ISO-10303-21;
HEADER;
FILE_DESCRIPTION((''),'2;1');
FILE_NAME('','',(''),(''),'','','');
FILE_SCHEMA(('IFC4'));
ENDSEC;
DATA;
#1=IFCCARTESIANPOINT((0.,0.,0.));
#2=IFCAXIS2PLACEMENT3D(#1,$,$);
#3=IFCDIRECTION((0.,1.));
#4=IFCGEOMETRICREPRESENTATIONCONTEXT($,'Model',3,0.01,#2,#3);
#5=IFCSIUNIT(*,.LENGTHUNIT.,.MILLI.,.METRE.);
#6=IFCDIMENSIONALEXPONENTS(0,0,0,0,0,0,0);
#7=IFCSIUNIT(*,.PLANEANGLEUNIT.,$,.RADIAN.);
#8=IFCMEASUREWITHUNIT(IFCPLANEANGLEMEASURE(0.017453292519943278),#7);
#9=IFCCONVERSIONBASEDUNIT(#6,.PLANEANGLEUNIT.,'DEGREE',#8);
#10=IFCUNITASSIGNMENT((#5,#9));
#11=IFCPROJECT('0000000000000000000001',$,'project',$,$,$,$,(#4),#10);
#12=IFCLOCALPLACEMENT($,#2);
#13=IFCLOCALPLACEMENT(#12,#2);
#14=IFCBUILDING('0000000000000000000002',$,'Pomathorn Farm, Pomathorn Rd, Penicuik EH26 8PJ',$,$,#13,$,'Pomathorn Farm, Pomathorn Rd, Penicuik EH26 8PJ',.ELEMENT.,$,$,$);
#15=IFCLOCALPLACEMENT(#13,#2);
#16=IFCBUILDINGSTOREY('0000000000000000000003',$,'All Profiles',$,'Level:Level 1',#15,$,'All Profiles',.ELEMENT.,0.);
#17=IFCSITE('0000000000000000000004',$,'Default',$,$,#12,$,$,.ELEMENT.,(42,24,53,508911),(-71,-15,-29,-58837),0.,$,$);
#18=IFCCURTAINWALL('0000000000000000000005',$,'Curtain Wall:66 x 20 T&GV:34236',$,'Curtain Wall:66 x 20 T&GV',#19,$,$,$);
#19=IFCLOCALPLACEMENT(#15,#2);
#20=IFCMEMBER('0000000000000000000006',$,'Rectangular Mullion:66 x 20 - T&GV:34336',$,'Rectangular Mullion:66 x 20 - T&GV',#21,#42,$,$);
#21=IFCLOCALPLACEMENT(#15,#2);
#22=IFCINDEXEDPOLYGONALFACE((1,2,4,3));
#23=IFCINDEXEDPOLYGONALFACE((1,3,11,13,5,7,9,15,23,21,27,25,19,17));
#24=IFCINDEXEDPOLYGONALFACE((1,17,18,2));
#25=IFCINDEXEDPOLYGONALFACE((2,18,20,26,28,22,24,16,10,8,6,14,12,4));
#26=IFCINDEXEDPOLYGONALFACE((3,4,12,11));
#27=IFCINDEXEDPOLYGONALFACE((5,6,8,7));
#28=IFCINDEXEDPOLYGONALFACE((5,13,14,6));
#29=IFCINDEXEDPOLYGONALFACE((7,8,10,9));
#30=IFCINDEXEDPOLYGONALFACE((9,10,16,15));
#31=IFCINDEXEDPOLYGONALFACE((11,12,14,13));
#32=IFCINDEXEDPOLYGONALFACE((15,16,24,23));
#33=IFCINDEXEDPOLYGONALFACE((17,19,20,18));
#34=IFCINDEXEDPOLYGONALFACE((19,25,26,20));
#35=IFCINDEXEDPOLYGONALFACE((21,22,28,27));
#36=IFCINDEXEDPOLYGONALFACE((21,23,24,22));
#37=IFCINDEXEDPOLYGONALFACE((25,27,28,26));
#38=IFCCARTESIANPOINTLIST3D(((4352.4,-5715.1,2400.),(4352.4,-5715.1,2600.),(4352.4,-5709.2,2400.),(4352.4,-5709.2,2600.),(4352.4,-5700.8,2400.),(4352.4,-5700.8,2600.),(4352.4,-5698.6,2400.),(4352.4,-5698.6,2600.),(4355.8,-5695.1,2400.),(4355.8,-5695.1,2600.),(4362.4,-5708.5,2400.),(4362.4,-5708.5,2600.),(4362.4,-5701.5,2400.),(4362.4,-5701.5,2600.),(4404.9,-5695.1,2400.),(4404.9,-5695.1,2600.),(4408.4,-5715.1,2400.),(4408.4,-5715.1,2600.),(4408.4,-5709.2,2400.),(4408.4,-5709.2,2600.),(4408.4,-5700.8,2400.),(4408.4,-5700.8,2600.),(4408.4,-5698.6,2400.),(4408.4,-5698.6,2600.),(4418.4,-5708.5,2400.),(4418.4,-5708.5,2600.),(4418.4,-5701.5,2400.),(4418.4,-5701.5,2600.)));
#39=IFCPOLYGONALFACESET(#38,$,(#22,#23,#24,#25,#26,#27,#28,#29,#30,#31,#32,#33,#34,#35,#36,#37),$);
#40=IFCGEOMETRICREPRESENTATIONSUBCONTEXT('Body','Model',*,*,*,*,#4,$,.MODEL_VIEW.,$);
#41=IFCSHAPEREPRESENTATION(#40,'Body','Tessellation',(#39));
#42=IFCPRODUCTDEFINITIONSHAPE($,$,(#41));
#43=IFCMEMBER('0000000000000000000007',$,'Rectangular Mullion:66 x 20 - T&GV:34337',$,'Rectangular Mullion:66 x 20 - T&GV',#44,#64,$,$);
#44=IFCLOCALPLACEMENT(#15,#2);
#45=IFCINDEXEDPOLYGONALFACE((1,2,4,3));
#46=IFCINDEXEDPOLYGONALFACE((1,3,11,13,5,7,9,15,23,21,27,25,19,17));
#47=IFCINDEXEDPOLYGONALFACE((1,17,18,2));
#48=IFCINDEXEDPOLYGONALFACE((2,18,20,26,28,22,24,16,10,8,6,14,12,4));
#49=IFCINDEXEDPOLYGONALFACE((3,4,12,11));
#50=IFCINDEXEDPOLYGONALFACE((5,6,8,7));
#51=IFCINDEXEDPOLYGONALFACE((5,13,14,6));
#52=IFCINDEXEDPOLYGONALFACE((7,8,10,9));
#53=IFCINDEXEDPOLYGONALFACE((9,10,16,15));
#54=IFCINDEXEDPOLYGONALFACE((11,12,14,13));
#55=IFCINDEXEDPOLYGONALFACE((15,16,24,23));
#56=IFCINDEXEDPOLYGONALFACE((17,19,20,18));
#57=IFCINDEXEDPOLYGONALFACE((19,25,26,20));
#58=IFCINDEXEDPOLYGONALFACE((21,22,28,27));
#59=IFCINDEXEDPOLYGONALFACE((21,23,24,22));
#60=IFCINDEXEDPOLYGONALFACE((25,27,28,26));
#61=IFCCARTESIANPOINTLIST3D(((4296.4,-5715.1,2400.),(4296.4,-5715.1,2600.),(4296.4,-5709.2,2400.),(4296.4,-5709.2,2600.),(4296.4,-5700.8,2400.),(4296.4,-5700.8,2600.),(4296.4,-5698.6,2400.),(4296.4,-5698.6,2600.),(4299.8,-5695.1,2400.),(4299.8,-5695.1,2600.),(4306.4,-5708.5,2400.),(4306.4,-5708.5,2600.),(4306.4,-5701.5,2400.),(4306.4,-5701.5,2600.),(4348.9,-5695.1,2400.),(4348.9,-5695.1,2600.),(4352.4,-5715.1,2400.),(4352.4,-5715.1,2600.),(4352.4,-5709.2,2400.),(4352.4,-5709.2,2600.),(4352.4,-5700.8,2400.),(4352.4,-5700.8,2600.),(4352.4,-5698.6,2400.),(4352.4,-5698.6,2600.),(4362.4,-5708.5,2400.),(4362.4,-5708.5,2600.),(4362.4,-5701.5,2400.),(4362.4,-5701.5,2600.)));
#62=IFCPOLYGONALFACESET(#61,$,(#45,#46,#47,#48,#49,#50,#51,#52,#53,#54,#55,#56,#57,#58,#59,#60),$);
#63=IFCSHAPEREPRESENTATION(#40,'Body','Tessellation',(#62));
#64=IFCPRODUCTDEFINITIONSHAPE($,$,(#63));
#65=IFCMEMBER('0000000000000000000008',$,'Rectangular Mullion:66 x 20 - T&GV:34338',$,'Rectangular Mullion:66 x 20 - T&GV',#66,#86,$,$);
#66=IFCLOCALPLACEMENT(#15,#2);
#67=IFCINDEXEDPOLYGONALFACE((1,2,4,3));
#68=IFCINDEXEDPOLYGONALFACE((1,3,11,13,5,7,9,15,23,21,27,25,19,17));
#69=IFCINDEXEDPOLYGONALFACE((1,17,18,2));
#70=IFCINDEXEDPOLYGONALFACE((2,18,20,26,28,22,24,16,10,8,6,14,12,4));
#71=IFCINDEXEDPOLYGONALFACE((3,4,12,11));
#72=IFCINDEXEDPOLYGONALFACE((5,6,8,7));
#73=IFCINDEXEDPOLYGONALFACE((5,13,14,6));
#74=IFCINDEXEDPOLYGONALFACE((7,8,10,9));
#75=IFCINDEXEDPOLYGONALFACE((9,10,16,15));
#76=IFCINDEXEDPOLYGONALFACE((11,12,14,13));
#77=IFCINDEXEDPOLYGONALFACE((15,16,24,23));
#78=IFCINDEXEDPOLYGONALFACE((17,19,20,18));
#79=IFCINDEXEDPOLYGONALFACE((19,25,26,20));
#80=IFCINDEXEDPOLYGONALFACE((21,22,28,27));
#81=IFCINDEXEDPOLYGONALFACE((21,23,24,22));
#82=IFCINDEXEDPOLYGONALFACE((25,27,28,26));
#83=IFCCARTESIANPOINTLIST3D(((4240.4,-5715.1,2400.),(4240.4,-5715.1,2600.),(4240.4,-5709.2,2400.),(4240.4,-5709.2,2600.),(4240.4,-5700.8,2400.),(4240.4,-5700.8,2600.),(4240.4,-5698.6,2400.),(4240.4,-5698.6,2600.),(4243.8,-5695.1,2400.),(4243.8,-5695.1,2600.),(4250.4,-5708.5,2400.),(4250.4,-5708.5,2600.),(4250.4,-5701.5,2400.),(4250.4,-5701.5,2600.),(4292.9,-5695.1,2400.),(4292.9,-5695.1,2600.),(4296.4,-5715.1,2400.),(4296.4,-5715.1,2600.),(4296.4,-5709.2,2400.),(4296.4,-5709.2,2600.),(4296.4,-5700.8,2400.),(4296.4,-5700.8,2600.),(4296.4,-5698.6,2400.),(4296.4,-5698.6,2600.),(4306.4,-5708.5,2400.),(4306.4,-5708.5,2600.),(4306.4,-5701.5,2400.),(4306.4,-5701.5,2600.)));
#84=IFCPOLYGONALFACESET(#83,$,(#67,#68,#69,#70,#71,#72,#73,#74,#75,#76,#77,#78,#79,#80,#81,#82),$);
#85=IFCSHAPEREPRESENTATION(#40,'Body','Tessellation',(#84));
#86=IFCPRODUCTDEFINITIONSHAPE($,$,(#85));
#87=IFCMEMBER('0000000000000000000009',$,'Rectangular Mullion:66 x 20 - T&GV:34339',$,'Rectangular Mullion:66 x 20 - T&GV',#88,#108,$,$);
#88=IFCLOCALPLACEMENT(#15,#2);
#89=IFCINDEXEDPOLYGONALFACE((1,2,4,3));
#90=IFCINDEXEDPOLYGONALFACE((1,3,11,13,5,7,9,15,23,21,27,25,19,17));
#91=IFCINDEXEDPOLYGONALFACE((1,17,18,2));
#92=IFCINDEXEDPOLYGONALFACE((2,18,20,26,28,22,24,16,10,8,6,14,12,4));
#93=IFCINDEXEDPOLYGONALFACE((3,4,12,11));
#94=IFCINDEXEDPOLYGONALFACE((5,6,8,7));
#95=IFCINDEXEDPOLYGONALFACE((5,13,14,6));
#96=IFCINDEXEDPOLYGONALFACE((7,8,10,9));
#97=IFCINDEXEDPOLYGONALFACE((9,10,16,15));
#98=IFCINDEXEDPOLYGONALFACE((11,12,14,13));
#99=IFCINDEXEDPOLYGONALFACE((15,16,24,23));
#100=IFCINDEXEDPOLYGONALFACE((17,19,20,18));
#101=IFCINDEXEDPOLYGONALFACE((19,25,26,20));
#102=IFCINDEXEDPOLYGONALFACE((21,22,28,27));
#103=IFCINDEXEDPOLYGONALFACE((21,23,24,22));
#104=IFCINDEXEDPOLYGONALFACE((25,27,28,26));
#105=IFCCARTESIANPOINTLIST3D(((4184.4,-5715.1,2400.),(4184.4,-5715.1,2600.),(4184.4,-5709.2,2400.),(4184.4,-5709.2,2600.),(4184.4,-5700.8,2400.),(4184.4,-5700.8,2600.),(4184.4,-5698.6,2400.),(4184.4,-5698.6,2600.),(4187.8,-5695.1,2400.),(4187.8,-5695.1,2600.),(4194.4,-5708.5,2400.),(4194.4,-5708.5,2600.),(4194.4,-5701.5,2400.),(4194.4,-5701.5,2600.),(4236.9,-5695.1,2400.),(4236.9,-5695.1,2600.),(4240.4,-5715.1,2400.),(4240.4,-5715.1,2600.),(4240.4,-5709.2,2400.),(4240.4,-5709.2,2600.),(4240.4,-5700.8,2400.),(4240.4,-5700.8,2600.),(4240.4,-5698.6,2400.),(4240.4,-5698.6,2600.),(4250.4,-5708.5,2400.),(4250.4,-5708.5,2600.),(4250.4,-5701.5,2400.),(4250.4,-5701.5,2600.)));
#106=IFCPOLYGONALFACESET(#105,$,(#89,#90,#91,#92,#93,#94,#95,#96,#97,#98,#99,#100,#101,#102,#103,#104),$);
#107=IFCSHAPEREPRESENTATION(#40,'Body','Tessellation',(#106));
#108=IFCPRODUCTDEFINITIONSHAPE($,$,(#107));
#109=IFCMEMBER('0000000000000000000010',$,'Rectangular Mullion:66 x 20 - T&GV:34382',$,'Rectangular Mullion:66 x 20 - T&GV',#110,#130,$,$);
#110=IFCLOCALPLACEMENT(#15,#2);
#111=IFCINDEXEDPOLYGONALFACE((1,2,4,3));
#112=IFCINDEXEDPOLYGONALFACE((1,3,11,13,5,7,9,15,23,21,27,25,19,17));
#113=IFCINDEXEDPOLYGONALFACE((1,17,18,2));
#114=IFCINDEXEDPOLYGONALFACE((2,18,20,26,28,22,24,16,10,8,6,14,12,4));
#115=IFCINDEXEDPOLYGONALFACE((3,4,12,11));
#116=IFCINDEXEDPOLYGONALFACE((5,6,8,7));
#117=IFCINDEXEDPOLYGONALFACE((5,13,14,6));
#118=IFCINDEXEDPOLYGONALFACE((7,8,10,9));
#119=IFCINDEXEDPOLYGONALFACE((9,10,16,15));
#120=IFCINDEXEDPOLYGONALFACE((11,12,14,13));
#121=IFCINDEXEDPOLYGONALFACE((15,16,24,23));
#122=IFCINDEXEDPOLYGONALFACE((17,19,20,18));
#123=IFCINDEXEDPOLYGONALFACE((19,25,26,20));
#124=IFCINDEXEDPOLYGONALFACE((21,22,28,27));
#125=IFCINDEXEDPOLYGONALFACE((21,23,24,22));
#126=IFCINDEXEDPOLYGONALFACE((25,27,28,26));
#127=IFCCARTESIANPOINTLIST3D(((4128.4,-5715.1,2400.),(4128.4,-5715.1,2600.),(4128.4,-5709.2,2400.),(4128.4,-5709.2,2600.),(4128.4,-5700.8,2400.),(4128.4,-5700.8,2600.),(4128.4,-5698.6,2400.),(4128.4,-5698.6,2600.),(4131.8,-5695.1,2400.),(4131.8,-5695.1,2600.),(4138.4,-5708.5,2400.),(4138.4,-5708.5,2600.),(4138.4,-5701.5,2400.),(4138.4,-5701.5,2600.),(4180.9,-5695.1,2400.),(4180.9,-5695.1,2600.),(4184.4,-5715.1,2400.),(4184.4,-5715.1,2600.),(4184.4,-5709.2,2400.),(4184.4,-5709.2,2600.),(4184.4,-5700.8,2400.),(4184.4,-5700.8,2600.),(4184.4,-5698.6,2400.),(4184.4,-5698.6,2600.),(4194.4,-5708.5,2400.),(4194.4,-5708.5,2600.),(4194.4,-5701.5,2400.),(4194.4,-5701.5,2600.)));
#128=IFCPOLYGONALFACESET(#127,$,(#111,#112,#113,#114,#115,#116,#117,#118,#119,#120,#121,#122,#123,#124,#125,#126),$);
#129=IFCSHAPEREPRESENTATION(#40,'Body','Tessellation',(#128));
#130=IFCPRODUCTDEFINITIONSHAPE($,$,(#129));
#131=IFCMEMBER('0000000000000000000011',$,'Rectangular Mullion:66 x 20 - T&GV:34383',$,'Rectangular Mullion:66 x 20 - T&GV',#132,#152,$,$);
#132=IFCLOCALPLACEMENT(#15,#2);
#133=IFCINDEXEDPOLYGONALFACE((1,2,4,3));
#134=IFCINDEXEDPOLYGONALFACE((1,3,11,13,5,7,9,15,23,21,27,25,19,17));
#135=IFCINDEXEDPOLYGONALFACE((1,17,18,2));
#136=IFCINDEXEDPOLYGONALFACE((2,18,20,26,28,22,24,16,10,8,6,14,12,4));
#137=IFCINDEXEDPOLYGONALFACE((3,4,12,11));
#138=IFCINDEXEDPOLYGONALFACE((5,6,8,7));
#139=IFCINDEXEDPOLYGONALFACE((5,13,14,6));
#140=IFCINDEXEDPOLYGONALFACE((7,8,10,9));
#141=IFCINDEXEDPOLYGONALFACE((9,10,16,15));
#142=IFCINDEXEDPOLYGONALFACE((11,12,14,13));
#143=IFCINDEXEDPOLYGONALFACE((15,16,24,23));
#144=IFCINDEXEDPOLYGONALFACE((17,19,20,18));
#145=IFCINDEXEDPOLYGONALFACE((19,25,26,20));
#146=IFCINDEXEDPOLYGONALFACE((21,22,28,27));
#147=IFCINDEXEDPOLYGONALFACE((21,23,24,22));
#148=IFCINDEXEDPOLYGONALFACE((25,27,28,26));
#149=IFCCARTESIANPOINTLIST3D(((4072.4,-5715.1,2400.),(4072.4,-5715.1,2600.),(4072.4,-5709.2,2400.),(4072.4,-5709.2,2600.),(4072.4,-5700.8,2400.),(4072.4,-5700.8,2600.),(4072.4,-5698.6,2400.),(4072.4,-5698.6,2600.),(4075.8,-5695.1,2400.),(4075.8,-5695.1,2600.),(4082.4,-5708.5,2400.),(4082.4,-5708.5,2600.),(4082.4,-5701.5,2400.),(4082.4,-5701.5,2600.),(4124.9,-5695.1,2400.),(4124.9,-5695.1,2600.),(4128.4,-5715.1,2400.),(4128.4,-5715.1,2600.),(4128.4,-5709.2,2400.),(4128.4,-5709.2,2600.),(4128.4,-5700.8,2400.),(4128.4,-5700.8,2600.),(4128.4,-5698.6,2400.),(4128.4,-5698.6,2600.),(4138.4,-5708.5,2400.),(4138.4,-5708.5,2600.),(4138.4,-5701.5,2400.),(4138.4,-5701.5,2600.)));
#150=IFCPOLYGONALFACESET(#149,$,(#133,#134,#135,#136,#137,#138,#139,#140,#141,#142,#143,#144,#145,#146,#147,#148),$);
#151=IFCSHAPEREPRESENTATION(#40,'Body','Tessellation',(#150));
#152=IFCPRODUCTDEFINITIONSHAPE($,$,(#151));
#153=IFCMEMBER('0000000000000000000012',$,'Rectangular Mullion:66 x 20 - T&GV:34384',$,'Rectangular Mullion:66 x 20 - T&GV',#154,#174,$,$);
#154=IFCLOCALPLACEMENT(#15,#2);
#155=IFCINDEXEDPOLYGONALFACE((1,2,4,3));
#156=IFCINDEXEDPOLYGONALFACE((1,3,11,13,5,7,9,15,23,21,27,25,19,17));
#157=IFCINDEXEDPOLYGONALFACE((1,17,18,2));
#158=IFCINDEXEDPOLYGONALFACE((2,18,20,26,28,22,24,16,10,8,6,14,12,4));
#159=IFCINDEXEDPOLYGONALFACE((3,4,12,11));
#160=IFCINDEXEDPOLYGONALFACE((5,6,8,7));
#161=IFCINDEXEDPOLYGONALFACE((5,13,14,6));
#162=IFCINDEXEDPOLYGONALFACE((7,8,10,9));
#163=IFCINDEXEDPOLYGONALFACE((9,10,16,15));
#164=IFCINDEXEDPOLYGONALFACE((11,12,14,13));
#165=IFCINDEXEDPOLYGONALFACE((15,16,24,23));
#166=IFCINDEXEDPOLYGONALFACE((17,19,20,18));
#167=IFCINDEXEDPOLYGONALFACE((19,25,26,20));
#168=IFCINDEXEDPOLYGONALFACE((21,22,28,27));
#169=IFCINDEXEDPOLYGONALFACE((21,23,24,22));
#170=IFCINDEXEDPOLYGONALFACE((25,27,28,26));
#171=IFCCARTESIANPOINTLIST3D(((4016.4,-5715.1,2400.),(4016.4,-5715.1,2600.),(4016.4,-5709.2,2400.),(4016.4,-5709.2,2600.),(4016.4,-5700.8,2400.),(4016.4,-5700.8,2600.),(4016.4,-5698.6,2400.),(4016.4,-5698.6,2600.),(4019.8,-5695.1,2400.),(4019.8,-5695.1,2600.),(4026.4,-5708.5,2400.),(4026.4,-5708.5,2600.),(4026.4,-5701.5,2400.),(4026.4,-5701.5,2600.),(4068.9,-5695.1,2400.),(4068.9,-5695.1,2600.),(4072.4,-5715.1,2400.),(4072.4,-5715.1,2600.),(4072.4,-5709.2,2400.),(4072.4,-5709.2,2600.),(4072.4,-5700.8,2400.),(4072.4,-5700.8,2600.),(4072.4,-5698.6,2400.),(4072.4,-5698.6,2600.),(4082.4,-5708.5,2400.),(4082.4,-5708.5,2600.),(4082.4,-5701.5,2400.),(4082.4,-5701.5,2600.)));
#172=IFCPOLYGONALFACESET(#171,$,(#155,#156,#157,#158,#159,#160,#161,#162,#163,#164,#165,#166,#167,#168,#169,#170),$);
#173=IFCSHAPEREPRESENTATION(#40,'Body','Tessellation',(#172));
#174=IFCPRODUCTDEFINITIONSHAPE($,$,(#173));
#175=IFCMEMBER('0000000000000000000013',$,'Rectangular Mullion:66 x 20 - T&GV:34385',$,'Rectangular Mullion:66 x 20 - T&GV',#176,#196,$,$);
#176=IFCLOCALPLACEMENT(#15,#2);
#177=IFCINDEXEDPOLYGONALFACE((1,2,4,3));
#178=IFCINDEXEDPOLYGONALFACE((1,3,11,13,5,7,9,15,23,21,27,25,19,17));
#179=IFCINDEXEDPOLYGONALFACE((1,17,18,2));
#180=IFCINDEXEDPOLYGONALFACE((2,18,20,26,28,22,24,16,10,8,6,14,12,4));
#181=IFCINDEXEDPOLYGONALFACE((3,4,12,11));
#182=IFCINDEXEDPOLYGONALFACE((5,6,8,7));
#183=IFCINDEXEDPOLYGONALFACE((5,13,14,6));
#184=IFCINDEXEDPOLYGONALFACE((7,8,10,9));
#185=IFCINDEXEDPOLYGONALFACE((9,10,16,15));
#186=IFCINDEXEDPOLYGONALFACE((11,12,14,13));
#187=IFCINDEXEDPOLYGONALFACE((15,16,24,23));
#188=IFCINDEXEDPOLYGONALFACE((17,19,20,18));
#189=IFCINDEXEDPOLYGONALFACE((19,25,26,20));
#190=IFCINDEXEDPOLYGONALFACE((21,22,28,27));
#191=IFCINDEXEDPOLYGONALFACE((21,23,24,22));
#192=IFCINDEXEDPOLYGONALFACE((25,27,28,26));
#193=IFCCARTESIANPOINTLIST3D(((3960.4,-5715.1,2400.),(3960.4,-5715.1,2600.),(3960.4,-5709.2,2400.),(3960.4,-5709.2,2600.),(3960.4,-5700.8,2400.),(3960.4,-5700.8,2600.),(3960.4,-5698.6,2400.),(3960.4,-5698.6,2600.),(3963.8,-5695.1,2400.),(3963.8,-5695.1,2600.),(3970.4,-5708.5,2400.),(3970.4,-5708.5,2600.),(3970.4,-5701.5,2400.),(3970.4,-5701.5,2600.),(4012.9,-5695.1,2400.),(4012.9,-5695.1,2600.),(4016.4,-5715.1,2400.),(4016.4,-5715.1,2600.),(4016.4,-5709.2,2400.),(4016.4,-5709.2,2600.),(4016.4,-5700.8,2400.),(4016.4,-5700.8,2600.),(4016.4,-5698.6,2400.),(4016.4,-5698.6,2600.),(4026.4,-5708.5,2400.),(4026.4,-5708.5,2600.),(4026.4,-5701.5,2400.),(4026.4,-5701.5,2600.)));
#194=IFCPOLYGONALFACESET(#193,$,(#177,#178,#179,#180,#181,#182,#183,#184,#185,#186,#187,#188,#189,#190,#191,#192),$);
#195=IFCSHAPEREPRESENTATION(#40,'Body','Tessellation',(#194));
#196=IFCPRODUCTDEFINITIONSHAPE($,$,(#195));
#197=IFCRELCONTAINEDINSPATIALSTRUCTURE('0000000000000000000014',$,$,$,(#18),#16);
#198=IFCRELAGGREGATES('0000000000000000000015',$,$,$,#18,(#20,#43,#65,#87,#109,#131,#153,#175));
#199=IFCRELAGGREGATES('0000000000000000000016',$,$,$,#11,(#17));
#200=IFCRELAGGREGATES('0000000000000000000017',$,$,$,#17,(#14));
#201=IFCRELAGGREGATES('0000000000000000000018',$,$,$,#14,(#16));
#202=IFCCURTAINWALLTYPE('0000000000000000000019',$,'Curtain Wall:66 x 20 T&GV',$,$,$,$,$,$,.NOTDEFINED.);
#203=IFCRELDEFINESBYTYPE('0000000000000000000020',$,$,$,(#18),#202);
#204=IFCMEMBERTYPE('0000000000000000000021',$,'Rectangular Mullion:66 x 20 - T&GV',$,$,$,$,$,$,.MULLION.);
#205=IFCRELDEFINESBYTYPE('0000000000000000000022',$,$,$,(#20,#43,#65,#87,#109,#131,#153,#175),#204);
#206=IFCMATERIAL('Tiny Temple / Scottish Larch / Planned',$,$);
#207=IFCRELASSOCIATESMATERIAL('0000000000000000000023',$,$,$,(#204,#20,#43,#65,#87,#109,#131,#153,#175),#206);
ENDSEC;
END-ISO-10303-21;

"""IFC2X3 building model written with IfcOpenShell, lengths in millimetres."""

from ifc_helpers import new_model, entity, si_unit, converted_unit, direction, frame, origin, place, context, subcontext, project, spatial, polyline, outline, extrude, source, transform, mapped, material, type_object, type_shapes, element, aggregate, save


model = new_model("IFC2X3")

# Units and contexts
model_context = context("Model", 3, precision=0.01, world=origin(), true_north=direction((0.0, 1.0)))
body_context = subcontext(model_context, "Body", "Model", "MODEL_VIEW")
ifc_project = project(units=[si_unit("LENGTHUNIT", "METRE", prefix="MILLI"), converted_unit("PLANEANGLEUNIT", "DEGREE", entity("IfcPlaneAngleMeasure", 0.017453292519943278), si_unit("PLANEANGLEUNIT", "RADIAN"), dimensions=[0, 0, 0, 0, 0, 0, 0])], contexts=[model_context])

# Site, building, storey
site_placement = place(None, origin())
site = spatial("IfcSite", under=ifc_project, at=site_placement, Name="Default", CompositionType="ELEMENT", RefLatitude=(42, 24, 53, 508911), RefLongitude=(-71, -15, -29, -58837), RefElevation=0.0)
building_placement = place(site_placement, origin())
building = spatial("IfcBuilding", under=site, at=building_placement, Name="Pomathorn Farm, Pomathorn Rd, Penicuik EH26 8PJ", LongName="Pomathorn Farm, Pomathorn Rd, Penicuik EH26 8PJ", CompositionType="ELEMENT")
storey_placement = place(building_placement, origin())
storey = spatial("IfcBuildingStorey", under=building, at=storey_placement, Name="All Profiles", ObjectType="Level:Level 1", LongName="All Profiles", CompositionType="ELEMENT", Elevation=0.0)

# Curtain wall, members
curtain_wall_type = type_object("IfcCurtainWallType", Name="Curtain Wall:66 x 20 T&GV", PredefinedType="NOTDEFINED")
curtain_wall_placement = place(storey_placement, origin())
curtain_wall = element("IfcCurtainWall", 1, at=curtain_wall_placement, inside=storey, type_object=curtain_wall_type, Name="Curtain Wall:66 x 20 T&GV:34236", ObjectType="Curtain Wall:66 x 20 T&GV")
ifc_material = material(Name="Tiny Temple / Scottish Larch / Planned")
member_type = type_object("IfcMemberType", Name="Rectangular Mullion:66 x 20 - T&GV", PredefinedType="MULLION", material=ifc_material)
shared_shape = source(origin(), body_context, "Body", "SweptSolid", [
    extrude(outline(polyline([(-25.1, -11.0), (30.9, -11.0), (30.9, -5.1), (20.9, -4.4), (20.9, 2.6), (30.9, 3.3), (30.9, 5.5), (27.4, 9.0), (-21.7, 9.0), (-25.1, 5.5), (-25.1, 3.3), (-35.1, 2.6), (-35.1, -4.4), (-25.1, -5.1), (-25.1, -11.0)])), frame((-35.1, -11.0, -200.0), z_axis=(0.0, 0.0, 1.0), x_axis=(-1.0, 0.0, 0.0)), (0.0, 0.0, 1.0), 200.0),
])
type_shapes(member_type, [shared_shape])
member_1_placement = place(curtain_wall_placement, frame((4418.4, -5715.1, 2400.0), z_axis=(0.0, 0.0, -1.0), x_axis=(1.0, 0.0, 0.0)))
member_1 = element("IfcMember", 2, at=member_1_placement, type_object=member_type, material=ifc_material, Name="Rectangular Mullion:66 x 20 - T&GV:34336", ObjectType="Rectangular Mullion:66 x 20 - T&GV", context=body_context, shape_type="MappedRepresentation", body=[
    mapped(shared_shape, transform((0.0, 0.0, 0.0), scale=1.0)),
])
member_2_placement = place(curtain_wall_placement, frame((4362.4, -5715.1, 2400.0), z_axis=(0.0, 0.0, -1.0), x_axis=(1.0, 0.0, 0.0)))
member_2 = element("IfcMember", 3, at=member_2_placement, type_object=member_type, material=ifc_material, Name="Rectangular Mullion:66 x 20 - T&GV:34337", ObjectType="Rectangular Mullion:66 x 20 - T&GV", context=body_context, shape_type="MappedRepresentation", body=[
    mapped(shared_shape, transform((0.0, 0.0, 0.0), scale=1.0)),
])
member_3_placement = place(curtain_wall_placement, frame((4306.4, -5715.1, 2400.0), z_axis=(0.0, 0.0, -1.0), x_axis=(1.0, 0.0, 0.0)))
member_3 = element("IfcMember", 4, at=member_3_placement, type_object=member_type, material=ifc_material, Name="Rectangular Mullion:66 x 20 - T&GV:34338", ObjectType="Rectangular Mullion:66 x 20 - T&GV", context=body_context, shape_type="MappedRepresentation", body=[
    mapped(shared_shape, transform((0.0, 0.0, 0.0), scale=1.0)),
])
member_4_placement = place(curtain_wall_placement, frame((4250.4, -5715.1, 2400.0), z_axis=(0.0, 0.0, -1.0), x_axis=(1.0, 0.0, 0.0)))
member_4 = element("IfcMember", 5, at=member_4_placement, type_object=member_type, material=ifc_material, Name="Rectangular Mullion:66 x 20 - T&GV:34339", ObjectType="Rectangular Mullion:66 x 20 - T&GV", context=body_context, shape_type="MappedRepresentation", body=[
    mapped(shared_shape, transform((0.0, 0.0, 0.0), scale=1.0)),
])
member_5_placement = place(curtain_wall_placement, frame((4194.4, -5715.1, 2400.0), z_axis=(0.0, 0.0, -1.0), x_axis=(1.0, 0.0, 0.0)))
member_5 = element("IfcMember", 6, at=member_5_placement, type_object=member_type, material=ifc_material, Name="Rectangular Mullion:66 x 20 - T&GV:34382", ObjectType="Rectangular Mullion:66 x 20 - T&GV", context=body_context, shape_type="MappedRepresentation", body=[
    mapped(shared_shape, transform((0.0, 0.0, 0.0), scale=1.0)),
])
member_6_placement = place(curtain_wall_placement, frame((4138.4, -5715.1, 2400.0), z_axis=(0.0, 0.0, -1.0), x_axis=(1.0, 0.0, 0.0)))
member_6 = element("IfcMember", 7, at=member_6_placement, type_object=member_type, material=ifc_material, Name="Rectangular Mullion:66 x 20 - T&GV:34383", ObjectType="Rectangular Mullion:66 x 20 - T&GV", context=body_context, shape_type="MappedRepresentation", body=[
    mapped(shared_shape, transform((0.0, 0.0, 0.0), scale=1.0)),
])
member_7_placement = place(curtain_wall_placement, frame((4082.4, -5715.1, 2400.0), z_axis=(0.0, 0.0, -1.0), x_axis=(1.0, 0.0, 0.0)))
member_7 = element("IfcMember", 8, at=member_7_placement, type_object=member_type, material=ifc_material, Name="Rectangular Mullion:66 x 20 - T&GV:34384", ObjectType="Rectangular Mullion:66 x 20 - T&GV", context=body_context, shape_type="MappedRepresentation", body=[
    mapped(shared_shape, transform((0.0, 0.0, 0.0), scale=1.0)),
])
member_8_placement = place(curtain_wall_placement, frame((4026.4, -5715.1, 2400.0), z_axis=(0.0, 0.0, -1.0), x_axis=(1.0, 0.0, 0.0)))
member_8 = element("IfcMember", 9, at=member_8_placement, type_object=member_type, material=ifc_material, Name="Rectangular Mullion:66 x 20 - T&GV:34385", ObjectType="Rectangular Mullion:66 x 20 - T&GV", context=body_context, shape_type="MappedRepresentation", body=[
    mapped(shared_shape, transform((0.0, 0.0, 0.0), scale=1.0)),
])
aggregate(curtain_wall, [member_1, member_2, member_3, member_4, member_5, member_6, member_7, member_8])

save(model, "model.ifc")
